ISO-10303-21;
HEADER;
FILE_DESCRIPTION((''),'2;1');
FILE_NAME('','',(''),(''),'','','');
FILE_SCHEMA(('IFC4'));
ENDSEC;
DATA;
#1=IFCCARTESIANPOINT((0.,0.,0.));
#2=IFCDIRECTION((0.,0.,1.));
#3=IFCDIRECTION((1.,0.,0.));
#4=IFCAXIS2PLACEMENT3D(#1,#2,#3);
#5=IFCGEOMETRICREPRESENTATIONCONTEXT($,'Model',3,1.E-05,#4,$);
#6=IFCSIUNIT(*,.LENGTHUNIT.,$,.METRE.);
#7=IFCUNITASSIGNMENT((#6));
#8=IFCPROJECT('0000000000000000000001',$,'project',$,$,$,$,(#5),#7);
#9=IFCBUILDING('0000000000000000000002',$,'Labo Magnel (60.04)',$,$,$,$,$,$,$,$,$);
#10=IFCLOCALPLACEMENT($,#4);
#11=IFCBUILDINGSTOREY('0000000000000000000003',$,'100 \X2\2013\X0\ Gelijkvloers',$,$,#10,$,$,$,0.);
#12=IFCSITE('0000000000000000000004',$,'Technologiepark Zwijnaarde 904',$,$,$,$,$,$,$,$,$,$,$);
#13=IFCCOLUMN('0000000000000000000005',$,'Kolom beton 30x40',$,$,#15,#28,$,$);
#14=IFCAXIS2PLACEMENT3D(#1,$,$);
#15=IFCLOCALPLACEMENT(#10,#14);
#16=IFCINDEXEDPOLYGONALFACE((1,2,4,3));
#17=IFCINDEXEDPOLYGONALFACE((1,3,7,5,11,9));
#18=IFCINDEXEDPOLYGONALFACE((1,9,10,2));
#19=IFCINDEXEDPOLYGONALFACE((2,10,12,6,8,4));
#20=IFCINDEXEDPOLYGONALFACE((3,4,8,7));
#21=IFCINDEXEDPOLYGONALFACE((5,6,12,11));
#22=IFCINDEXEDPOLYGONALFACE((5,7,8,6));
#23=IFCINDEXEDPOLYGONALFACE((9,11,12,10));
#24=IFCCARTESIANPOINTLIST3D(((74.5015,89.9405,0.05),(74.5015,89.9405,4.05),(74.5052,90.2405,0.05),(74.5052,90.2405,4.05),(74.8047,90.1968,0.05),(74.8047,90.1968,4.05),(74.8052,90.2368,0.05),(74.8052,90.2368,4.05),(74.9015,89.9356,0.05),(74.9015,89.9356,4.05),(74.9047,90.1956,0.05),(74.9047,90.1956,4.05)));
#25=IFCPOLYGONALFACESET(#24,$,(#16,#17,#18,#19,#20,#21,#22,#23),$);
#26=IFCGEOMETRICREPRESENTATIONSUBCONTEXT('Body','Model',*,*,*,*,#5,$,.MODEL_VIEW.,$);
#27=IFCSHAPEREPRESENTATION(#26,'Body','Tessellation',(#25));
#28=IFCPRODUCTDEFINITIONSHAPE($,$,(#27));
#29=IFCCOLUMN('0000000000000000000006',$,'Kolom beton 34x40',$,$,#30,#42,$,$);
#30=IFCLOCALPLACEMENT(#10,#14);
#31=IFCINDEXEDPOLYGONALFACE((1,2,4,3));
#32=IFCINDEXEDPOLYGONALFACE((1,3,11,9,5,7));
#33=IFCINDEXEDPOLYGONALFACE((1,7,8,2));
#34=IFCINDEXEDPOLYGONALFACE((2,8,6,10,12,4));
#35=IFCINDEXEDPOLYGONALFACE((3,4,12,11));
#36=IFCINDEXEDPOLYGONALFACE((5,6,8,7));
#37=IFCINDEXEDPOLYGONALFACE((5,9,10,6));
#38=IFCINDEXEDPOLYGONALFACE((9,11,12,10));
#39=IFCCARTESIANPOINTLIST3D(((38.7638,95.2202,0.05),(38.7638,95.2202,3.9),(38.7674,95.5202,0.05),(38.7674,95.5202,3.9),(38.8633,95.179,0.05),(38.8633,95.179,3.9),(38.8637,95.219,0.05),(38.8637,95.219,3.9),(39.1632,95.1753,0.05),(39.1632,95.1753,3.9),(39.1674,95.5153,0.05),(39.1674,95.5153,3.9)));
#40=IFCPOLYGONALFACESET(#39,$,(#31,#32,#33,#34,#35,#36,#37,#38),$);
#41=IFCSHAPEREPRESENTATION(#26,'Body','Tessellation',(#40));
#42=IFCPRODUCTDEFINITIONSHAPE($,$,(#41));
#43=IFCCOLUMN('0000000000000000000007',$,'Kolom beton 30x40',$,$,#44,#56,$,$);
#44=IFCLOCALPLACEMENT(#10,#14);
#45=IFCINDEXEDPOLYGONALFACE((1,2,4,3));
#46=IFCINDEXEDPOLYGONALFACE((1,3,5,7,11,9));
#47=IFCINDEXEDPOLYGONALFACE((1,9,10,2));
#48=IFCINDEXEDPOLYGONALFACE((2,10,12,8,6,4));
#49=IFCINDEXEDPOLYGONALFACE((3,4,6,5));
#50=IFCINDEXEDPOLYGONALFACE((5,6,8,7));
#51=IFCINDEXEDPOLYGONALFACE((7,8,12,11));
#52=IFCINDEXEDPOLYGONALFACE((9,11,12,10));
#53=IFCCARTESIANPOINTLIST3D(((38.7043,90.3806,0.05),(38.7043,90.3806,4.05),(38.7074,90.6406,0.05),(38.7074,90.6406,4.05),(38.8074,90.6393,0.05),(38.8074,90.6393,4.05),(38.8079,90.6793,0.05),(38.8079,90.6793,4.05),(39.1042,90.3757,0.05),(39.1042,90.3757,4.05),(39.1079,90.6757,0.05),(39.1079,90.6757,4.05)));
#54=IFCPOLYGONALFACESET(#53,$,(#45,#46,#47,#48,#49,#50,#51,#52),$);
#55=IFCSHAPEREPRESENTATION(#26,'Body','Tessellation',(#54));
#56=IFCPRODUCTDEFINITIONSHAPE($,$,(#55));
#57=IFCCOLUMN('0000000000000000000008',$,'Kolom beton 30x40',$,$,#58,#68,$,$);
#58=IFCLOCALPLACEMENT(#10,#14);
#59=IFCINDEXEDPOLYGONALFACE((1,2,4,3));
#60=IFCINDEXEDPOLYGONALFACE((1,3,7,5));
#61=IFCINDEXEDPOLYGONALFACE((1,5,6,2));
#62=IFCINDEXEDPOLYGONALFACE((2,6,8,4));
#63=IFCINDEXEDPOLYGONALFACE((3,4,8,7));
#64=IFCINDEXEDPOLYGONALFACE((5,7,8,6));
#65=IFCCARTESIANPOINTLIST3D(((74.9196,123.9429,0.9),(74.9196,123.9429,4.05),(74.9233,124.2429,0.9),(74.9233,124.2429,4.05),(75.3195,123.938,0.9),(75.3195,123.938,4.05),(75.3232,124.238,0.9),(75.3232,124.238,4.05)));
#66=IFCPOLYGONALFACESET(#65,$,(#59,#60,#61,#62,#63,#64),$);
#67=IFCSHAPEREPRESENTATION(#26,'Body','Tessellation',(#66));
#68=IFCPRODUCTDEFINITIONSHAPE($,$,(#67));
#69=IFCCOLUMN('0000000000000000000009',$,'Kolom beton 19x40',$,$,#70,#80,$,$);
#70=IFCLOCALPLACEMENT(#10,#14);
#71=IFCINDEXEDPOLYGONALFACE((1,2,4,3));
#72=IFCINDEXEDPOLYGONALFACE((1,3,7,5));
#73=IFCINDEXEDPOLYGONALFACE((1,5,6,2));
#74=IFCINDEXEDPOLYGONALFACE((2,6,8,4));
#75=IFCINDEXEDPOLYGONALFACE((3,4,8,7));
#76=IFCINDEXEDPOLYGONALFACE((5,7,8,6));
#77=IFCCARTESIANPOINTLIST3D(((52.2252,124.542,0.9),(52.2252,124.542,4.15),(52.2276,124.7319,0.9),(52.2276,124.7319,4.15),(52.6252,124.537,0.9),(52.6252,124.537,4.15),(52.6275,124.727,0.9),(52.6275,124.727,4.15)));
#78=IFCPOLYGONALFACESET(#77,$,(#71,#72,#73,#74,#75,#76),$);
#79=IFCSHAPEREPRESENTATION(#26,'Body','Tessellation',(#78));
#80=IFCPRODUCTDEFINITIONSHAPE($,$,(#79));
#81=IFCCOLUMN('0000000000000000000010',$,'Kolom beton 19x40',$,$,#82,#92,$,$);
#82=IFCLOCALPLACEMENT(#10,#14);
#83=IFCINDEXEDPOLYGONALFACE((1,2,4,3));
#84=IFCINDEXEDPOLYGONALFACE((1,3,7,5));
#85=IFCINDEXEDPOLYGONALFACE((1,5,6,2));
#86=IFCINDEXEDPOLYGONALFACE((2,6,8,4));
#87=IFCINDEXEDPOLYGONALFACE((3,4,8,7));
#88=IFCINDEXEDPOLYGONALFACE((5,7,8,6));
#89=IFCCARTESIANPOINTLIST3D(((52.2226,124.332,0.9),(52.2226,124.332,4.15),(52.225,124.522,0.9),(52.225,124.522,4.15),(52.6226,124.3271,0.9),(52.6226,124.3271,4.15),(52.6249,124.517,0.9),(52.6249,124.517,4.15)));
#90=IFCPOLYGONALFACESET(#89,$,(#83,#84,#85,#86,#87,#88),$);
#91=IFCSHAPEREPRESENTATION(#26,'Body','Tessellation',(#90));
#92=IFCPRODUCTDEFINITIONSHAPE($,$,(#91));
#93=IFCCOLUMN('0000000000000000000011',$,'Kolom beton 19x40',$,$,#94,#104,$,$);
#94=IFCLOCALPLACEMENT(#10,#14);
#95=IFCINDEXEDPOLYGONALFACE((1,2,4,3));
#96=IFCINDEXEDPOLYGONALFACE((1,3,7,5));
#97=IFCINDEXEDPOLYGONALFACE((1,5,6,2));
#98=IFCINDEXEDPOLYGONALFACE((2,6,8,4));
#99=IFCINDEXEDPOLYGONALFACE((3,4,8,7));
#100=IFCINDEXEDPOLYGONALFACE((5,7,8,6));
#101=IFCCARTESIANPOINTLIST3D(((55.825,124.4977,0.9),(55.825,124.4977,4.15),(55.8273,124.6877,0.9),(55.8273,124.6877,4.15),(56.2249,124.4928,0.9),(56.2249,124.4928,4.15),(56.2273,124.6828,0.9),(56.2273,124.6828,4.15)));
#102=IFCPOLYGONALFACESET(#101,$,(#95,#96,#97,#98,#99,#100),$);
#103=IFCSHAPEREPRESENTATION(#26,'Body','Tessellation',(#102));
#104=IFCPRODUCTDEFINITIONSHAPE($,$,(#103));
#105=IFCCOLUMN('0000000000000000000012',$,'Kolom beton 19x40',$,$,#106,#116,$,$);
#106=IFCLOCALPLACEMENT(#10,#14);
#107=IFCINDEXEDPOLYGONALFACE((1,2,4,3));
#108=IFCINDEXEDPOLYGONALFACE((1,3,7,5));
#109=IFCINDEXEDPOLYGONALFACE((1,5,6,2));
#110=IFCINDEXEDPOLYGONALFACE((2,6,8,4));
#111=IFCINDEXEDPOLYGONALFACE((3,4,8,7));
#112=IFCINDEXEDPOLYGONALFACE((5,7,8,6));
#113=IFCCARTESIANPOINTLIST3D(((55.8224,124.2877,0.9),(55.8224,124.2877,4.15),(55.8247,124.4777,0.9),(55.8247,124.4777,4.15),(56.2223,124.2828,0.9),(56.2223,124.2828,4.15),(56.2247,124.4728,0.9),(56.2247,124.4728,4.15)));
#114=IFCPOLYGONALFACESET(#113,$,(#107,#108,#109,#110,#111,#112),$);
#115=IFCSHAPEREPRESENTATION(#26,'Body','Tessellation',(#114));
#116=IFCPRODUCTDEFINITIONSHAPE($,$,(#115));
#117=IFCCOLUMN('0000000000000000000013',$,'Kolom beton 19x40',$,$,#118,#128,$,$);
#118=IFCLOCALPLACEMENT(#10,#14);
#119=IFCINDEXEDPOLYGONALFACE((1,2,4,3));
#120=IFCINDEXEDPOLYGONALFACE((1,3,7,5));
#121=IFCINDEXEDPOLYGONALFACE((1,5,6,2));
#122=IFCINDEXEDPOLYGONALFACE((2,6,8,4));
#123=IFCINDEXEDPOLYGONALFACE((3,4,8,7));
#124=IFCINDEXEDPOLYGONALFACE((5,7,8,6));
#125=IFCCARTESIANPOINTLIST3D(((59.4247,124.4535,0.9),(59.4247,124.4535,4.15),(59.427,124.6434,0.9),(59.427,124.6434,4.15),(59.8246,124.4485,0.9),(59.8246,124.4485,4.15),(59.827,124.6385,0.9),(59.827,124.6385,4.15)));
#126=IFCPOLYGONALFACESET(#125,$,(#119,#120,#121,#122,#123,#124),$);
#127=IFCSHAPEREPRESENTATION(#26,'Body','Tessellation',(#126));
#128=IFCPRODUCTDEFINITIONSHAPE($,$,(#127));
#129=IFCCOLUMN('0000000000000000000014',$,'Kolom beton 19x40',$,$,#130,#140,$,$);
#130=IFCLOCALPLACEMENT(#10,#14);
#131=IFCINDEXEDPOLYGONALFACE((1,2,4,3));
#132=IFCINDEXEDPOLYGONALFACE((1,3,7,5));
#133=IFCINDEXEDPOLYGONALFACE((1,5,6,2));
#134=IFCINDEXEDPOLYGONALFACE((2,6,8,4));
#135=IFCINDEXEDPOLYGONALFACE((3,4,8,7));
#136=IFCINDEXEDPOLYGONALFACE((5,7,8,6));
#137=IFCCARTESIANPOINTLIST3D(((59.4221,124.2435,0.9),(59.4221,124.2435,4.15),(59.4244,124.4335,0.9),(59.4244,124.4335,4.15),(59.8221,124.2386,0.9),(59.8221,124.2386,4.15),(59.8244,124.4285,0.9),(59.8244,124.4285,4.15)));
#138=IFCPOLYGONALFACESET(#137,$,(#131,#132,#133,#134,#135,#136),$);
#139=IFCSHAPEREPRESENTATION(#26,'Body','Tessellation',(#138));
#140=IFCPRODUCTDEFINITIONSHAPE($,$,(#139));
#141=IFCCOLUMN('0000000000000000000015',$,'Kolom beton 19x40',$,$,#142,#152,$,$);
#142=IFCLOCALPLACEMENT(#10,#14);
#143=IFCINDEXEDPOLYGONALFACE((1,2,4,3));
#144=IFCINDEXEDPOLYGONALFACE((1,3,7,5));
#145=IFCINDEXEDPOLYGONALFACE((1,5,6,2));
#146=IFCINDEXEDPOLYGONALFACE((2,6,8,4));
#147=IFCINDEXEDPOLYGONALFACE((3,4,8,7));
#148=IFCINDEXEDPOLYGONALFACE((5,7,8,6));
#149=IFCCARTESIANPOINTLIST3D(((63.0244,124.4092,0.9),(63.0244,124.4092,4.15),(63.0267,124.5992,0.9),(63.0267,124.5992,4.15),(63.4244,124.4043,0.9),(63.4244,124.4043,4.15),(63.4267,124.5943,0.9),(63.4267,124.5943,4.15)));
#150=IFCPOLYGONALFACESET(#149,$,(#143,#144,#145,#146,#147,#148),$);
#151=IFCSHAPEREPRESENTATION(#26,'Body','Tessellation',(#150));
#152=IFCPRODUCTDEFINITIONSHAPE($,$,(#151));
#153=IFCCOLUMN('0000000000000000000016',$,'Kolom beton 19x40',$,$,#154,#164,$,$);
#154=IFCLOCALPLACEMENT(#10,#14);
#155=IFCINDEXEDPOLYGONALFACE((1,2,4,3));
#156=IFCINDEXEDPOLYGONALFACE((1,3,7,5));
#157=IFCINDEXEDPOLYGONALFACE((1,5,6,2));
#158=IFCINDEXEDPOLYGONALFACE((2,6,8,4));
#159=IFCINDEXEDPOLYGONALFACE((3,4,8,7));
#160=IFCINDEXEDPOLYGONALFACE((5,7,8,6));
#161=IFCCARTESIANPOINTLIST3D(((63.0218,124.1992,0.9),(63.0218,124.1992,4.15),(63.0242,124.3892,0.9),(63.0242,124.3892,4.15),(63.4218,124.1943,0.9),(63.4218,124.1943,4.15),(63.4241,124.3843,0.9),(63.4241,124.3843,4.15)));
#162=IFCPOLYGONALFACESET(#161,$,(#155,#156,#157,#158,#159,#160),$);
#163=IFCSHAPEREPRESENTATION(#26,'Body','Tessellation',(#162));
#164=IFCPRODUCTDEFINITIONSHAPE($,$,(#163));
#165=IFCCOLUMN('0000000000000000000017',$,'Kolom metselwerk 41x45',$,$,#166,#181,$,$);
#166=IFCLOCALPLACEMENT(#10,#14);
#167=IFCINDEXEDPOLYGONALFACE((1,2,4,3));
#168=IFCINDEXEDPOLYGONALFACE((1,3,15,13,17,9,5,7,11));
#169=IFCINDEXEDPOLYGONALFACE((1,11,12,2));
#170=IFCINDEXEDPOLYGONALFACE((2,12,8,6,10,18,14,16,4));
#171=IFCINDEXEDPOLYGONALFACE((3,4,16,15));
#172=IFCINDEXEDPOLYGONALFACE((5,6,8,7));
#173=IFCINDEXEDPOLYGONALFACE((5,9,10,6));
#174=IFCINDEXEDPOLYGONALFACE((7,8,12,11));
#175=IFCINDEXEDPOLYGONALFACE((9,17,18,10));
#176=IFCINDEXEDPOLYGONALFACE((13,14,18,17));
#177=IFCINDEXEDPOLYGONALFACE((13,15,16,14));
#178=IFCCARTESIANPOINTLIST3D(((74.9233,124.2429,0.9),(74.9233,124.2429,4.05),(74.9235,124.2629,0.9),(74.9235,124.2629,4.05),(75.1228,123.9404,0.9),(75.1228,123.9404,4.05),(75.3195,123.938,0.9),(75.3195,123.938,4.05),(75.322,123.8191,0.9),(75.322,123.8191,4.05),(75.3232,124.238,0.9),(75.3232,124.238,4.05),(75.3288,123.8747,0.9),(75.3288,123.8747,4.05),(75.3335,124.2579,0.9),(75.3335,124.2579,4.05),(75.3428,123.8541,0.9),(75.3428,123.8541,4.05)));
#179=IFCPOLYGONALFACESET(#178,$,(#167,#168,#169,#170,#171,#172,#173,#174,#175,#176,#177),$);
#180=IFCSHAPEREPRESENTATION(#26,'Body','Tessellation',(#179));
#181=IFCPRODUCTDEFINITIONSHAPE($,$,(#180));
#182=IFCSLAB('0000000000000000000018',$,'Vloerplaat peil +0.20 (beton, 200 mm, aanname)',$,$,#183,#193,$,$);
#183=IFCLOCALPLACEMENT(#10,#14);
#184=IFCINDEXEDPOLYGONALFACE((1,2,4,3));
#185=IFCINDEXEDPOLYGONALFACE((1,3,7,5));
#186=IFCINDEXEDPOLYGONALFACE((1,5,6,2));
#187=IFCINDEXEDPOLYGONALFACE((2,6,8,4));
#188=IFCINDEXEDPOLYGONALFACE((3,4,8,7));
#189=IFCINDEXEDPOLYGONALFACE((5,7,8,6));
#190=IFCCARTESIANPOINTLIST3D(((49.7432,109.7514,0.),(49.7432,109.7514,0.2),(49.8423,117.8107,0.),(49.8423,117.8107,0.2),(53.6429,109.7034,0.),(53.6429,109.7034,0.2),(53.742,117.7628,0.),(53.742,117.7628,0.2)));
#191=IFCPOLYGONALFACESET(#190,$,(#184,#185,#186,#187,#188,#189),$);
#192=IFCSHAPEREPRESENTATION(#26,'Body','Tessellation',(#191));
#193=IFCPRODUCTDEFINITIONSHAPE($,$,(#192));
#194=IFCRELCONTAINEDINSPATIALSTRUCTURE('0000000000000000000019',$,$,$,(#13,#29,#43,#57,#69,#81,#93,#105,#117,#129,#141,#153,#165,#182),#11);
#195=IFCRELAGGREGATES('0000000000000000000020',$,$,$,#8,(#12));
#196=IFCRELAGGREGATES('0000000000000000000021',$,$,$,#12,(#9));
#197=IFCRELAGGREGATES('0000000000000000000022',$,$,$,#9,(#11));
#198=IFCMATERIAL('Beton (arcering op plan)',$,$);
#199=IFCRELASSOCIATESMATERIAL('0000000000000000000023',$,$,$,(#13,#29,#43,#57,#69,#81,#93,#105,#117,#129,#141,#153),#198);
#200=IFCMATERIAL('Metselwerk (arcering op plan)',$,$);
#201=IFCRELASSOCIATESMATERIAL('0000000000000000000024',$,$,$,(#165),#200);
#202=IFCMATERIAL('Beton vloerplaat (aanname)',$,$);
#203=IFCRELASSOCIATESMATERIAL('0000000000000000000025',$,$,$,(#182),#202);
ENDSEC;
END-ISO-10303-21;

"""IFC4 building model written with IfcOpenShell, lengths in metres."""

from ifc_helpers import new_model, si_unit, frame, origin, origin_with_axes, place, context, subcontext, project, spatial, polyline, outline, extrude, material, element, save


model = new_model("IFC4")

# Units and contexts
model_context = context("Model", 3, precision=1e-05, world=origin_with_axes())
body_context = subcontext(model_context, "Body", "Model", "MODEL_VIEW")
ifc_project = project(units=[si_unit("LENGTHUNIT", "METRE")], contexts=[model_context])

# Site, building, storey
site = spatial("IfcSite", under=ifc_project, Name="Technologiepark Zwijnaarde 904")
building = spatial("IfcBuilding", under=site, Name="Labo Magnel (60.04)")
storey_placement = place(None, origin_with_axes())
storey = spatial("IfcBuildingStorey", under=building, at=storey_placement, Name="100 – Gelijkvloers", Elevation=0.0)

# Columns
ifc_material_1 = material(Name="Beton (arcering op plan)")
column_1_placement = place(storey_placement, frame((0.0, 0.0, 0.05), z_axis=(0.0, 0.0, 1.0), x_axis=(1.0, 0.0, 0.0)))
element("IfcColumn", 1, at=column_1_placement, inside=storey, material=ifc_material_1, Name="Kolom beton 30x40", context=body_context, shape_type="SweptSolid", body=[
    extrude(outline(polyline([(74.9047, 90.1956), (74.8047, 90.1968), (74.8052, 90.2368), (74.5052, 90.2405), (74.5015, 89.9405), (74.9015, 89.9356), (74.9047, 90.1956)])), origin(), (0.0, 0.0, 1.0), 4.0),
])
column_2_placement = place(storey_placement, frame((0.0, 0.0, 0.05), z_axis=(0.0, 0.0, 1.0), x_axis=(1.0, 0.0, 0.0)))
element("IfcColumn", 2, at=column_2_placement, inside=storey, material=ifc_material_1, Name="Kolom beton 34x40", context=body_context, shape_type="SweptSolid", body=[
    extrude(outline(polyline([(39.1674, 95.5153), (38.7674, 95.5202), (38.7638, 95.2202), (38.8637, 95.219), (38.8633, 95.179), (39.1632, 95.1753), (39.1674, 95.5153)])), origin(), (0.0, 0.0, 1.0), 3.85),
])
column_3_placement = place(storey_placement, frame((0.0, 0.0, 0.05), z_axis=(0.0, 0.0, 1.0), x_axis=(1.0, 0.0, 0.0)))
element("IfcColumn", 3, at=column_3_placement, inside=storey, material=ifc_material_1, Name="Kolom beton 30x40", context=body_context, shape_type="SweptSolid", body=[
    extrude(outline(polyline([(39.1079, 90.6757), (38.8079, 90.6793), (38.8074, 90.6393), (38.7074, 90.6406), (38.7043, 90.3806), (39.1042, 90.3757), (39.1079, 90.6757)])), origin(), (0.0, 0.0, 1.0), 4.0),
])
column_4_placement = place(storey_placement, frame((0.0, 0.0, 0.9), z_axis=(0.0, 0.0, 1.0), x_axis=(1.0, 0.0, 0.0)))
element("IfcColumn", 4, at=column_4_placement, inside=storey, material=ifc_material_1, Name="Kolom beton 30x40", context=body_context, shape_type="SweptSolid", body=[
    extrude(outline(polyline([(75.3232, 124.238), (74.9233, 124.2429), (74.9196, 123.9429), (75.3195, 123.938), (75.3232, 124.238)])), origin(), (0.0, 0.0, 1.0), 3.15),
])
column_5_placement = place(storey_placement, frame((0.0, 0.0, 0.9), z_axis=(0.0, 0.0, 1.0), x_axis=(1.0, 0.0, 0.0)))
element("IfcColumn", 5, at=column_5_placement, inside=storey, material=ifc_material_1, Name="Kolom beton 19x40", context=body_context, shape_type="SweptSolid", body=[
    extrude(outline(polyline([(52.6275, 124.727), (52.2276, 124.7319), (52.2252, 124.542), (52.6252, 124.537), (52.6275, 124.727)])), origin(), (0.0, 0.0, 1.0), 3.25),
])
column_6_placement = place(storey_placement, frame((0.0, 0.0, 0.9), z_axis=(0.0, 0.0, 1.0), x_axis=(1.0, 0.0, 0.0)))
element("IfcColumn", 6, at=column_6_placement, inside=storey, material=ifc_material_1, Name="Kolom beton 19x40", context=body_context, shape_type="SweptSolid", body=[
    extrude(outline(polyline([(52.6249, 124.517), (52.225, 124.522), (52.2226, 124.332), (52.6226, 124.3271), (52.6249, 124.517)])), origin(), (0.0, 0.0, 1.0), 3.25),
])
column_7_placement = place(storey_placement, frame((0.0, 0.0, 0.9), z_axis=(0.0, 0.0, 1.0), x_axis=(1.0, 0.0, 0.0)))
element("IfcColumn", 7, at=column_7_placement, inside=storey, material=ifc_material_1, Name="Kolom beton 19x40", context=body_context, shape_type="SweptSolid", body=[
    extrude(outline(polyline([(56.2273, 124.6828), (55.8273, 124.6877), (55.825, 124.4977), (56.2249, 124.4928), (56.2273, 124.6828)])), origin(), (0.0, 0.0, 1.0), 3.25),
])
column_8_placement = place(storey_placement, frame((0.0, 0.0, 0.9), z_axis=(0.0, 0.0, 1.0), x_axis=(1.0, 0.0, 0.0)))
element("IfcColumn", 8, at=column_8_placement, inside=storey, material=ifc_material_1, Name="Kolom beton 19x40", context=body_context, shape_type="SweptSolid", body=[
    extrude(outline(polyline([(56.2247, 124.4728), (55.8247, 124.4777), (55.8224, 124.2877), (56.2223, 124.2828), (56.2247, 124.4728)])), origin(), (0.0, 0.0, 1.0), 3.25),
])
column_9_placement = place(storey_placement, frame((0.0, 0.0, 0.9), z_axis=(0.0, 0.0, 1.0), x_axis=(1.0, 0.0, 0.0)))
element("IfcColumn", 9, at=column_9_placement, inside=storey, material=ifc_material_1, Name="Kolom beton 19x40", context=body_context, shape_type="SweptSolid", body=[
    extrude(outline(polyline([(59.827, 124.6385), (59.427, 124.6434), (59.4247, 124.4535), (59.8246, 124.4485), (59.827, 124.6385)])), origin(), (0.0, 0.0, 1.0), 3.25),
])
column_10_placement = place(storey_placement, frame((0.0, 0.0, 0.9), z_axis=(0.0, 0.0, 1.0), x_axis=(1.0, 0.0, 0.0)))
element("IfcColumn", 10, at=column_10_placement, inside=storey, material=ifc_material_1, Name="Kolom beton 19x40", context=body_context, shape_type="SweptSolid", body=[
    extrude(outline(polyline([(59.8244, 124.4285), (59.4244, 124.4335), (59.4221, 124.2435), (59.8221, 124.2386), (59.8244, 124.4285)])), origin(), (0.0, 0.0, 1.0), 3.25),
])
column_11_placement = place(storey_placement, frame((0.0, 0.0, 0.9), z_axis=(0.0, 0.0, 1.0), x_axis=(1.0, 0.0, 0.0)))
element("IfcColumn", 11, at=column_11_placement, inside=storey, material=ifc_material_1, Name="Kolom beton 19x40", context=body_context, shape_type="SweptSolid", body=[
    extrude(outline(polyline([(63.4267, 124.5943), (63.0267, 124.5992), (63.0244, 124.4092), (63.4244, 124.4043), (63.4267, 124.5943)])), origin(), (0.0, 0.0, 1.0), 3.25),
])
column_12_placement = place(storey_placement, frame((0.0, 0.0, 0.9), z_axis=(0.0, 0.0, 1.0), x_axis=(1.0, 0.0, 0.0)))
element("IfcColumn", 12, at=column_12_placement, inside=storey, material=ifc_material_1, Name="Kolom beton 19x40", context=body_context, shape_type="SweptSolid", body=[
    extrude(outline(polyline([(63.4241, 124.3843), (63.0242, 124.3892), (63.0218, 124.1992), (63.4218, 124.1943), (63.4241, 124.3843)])), origin(), (0.0, 0.0, 1.0), 3.25),
])
ifc_material_2 = material(Name="Metselwerk (arcering op plan)")
column_13_placement = place(storey_placement, frame((0.0, 0.0, 0.9), z_axis=(0.0, 0.0, 1.0), x_axis=(1.0, 0.0, 0.0)))
element("IfcColumn", 13, at=column_13_placement, inside=storey, material=ifc_material_2, Name="Kolom metselwerk 41x45", context=body_context, shape_type="SweptSolid", body=[
    extrude(outline(polyline([(75.322, 123.8191), (75.3428, 123.8541), (75.3288, 123.8747), (75.3335, 124.2579), (74.9235, 124.2629), (74.9233, 124.2429), (75.3232, 124.238), (75.3195, 123.938), (75.1228, 123.9404), (75.322, 123.8191)])), origin(), (0.0, 0.0, 1.0), 3.15),
])

# Slab
ifc_material_3 = material(Name="Beton vloerplaat (aanname)")
slab_1_placement = place(storey_placement, origin_with_axes())
element("IfcSlab", 14, at=slab_1_placement, inside=storey, material=ifc_material_3, Name="Vloerplaat peil +0.20 (beton, 200 mm, aanname)", context=body_context, shape_type="SweptSolid", body=[
    extrude(outline(polyline([(49.8423, 117.8107), (53.742, 117.7628), (53.6429, 109.7034), (49.7432, 109.7514), (49.8423, 117.8107)])), origin(), (0.0, 0.0, 1.0), 0.2),
])

save(model, "model.ifc")
